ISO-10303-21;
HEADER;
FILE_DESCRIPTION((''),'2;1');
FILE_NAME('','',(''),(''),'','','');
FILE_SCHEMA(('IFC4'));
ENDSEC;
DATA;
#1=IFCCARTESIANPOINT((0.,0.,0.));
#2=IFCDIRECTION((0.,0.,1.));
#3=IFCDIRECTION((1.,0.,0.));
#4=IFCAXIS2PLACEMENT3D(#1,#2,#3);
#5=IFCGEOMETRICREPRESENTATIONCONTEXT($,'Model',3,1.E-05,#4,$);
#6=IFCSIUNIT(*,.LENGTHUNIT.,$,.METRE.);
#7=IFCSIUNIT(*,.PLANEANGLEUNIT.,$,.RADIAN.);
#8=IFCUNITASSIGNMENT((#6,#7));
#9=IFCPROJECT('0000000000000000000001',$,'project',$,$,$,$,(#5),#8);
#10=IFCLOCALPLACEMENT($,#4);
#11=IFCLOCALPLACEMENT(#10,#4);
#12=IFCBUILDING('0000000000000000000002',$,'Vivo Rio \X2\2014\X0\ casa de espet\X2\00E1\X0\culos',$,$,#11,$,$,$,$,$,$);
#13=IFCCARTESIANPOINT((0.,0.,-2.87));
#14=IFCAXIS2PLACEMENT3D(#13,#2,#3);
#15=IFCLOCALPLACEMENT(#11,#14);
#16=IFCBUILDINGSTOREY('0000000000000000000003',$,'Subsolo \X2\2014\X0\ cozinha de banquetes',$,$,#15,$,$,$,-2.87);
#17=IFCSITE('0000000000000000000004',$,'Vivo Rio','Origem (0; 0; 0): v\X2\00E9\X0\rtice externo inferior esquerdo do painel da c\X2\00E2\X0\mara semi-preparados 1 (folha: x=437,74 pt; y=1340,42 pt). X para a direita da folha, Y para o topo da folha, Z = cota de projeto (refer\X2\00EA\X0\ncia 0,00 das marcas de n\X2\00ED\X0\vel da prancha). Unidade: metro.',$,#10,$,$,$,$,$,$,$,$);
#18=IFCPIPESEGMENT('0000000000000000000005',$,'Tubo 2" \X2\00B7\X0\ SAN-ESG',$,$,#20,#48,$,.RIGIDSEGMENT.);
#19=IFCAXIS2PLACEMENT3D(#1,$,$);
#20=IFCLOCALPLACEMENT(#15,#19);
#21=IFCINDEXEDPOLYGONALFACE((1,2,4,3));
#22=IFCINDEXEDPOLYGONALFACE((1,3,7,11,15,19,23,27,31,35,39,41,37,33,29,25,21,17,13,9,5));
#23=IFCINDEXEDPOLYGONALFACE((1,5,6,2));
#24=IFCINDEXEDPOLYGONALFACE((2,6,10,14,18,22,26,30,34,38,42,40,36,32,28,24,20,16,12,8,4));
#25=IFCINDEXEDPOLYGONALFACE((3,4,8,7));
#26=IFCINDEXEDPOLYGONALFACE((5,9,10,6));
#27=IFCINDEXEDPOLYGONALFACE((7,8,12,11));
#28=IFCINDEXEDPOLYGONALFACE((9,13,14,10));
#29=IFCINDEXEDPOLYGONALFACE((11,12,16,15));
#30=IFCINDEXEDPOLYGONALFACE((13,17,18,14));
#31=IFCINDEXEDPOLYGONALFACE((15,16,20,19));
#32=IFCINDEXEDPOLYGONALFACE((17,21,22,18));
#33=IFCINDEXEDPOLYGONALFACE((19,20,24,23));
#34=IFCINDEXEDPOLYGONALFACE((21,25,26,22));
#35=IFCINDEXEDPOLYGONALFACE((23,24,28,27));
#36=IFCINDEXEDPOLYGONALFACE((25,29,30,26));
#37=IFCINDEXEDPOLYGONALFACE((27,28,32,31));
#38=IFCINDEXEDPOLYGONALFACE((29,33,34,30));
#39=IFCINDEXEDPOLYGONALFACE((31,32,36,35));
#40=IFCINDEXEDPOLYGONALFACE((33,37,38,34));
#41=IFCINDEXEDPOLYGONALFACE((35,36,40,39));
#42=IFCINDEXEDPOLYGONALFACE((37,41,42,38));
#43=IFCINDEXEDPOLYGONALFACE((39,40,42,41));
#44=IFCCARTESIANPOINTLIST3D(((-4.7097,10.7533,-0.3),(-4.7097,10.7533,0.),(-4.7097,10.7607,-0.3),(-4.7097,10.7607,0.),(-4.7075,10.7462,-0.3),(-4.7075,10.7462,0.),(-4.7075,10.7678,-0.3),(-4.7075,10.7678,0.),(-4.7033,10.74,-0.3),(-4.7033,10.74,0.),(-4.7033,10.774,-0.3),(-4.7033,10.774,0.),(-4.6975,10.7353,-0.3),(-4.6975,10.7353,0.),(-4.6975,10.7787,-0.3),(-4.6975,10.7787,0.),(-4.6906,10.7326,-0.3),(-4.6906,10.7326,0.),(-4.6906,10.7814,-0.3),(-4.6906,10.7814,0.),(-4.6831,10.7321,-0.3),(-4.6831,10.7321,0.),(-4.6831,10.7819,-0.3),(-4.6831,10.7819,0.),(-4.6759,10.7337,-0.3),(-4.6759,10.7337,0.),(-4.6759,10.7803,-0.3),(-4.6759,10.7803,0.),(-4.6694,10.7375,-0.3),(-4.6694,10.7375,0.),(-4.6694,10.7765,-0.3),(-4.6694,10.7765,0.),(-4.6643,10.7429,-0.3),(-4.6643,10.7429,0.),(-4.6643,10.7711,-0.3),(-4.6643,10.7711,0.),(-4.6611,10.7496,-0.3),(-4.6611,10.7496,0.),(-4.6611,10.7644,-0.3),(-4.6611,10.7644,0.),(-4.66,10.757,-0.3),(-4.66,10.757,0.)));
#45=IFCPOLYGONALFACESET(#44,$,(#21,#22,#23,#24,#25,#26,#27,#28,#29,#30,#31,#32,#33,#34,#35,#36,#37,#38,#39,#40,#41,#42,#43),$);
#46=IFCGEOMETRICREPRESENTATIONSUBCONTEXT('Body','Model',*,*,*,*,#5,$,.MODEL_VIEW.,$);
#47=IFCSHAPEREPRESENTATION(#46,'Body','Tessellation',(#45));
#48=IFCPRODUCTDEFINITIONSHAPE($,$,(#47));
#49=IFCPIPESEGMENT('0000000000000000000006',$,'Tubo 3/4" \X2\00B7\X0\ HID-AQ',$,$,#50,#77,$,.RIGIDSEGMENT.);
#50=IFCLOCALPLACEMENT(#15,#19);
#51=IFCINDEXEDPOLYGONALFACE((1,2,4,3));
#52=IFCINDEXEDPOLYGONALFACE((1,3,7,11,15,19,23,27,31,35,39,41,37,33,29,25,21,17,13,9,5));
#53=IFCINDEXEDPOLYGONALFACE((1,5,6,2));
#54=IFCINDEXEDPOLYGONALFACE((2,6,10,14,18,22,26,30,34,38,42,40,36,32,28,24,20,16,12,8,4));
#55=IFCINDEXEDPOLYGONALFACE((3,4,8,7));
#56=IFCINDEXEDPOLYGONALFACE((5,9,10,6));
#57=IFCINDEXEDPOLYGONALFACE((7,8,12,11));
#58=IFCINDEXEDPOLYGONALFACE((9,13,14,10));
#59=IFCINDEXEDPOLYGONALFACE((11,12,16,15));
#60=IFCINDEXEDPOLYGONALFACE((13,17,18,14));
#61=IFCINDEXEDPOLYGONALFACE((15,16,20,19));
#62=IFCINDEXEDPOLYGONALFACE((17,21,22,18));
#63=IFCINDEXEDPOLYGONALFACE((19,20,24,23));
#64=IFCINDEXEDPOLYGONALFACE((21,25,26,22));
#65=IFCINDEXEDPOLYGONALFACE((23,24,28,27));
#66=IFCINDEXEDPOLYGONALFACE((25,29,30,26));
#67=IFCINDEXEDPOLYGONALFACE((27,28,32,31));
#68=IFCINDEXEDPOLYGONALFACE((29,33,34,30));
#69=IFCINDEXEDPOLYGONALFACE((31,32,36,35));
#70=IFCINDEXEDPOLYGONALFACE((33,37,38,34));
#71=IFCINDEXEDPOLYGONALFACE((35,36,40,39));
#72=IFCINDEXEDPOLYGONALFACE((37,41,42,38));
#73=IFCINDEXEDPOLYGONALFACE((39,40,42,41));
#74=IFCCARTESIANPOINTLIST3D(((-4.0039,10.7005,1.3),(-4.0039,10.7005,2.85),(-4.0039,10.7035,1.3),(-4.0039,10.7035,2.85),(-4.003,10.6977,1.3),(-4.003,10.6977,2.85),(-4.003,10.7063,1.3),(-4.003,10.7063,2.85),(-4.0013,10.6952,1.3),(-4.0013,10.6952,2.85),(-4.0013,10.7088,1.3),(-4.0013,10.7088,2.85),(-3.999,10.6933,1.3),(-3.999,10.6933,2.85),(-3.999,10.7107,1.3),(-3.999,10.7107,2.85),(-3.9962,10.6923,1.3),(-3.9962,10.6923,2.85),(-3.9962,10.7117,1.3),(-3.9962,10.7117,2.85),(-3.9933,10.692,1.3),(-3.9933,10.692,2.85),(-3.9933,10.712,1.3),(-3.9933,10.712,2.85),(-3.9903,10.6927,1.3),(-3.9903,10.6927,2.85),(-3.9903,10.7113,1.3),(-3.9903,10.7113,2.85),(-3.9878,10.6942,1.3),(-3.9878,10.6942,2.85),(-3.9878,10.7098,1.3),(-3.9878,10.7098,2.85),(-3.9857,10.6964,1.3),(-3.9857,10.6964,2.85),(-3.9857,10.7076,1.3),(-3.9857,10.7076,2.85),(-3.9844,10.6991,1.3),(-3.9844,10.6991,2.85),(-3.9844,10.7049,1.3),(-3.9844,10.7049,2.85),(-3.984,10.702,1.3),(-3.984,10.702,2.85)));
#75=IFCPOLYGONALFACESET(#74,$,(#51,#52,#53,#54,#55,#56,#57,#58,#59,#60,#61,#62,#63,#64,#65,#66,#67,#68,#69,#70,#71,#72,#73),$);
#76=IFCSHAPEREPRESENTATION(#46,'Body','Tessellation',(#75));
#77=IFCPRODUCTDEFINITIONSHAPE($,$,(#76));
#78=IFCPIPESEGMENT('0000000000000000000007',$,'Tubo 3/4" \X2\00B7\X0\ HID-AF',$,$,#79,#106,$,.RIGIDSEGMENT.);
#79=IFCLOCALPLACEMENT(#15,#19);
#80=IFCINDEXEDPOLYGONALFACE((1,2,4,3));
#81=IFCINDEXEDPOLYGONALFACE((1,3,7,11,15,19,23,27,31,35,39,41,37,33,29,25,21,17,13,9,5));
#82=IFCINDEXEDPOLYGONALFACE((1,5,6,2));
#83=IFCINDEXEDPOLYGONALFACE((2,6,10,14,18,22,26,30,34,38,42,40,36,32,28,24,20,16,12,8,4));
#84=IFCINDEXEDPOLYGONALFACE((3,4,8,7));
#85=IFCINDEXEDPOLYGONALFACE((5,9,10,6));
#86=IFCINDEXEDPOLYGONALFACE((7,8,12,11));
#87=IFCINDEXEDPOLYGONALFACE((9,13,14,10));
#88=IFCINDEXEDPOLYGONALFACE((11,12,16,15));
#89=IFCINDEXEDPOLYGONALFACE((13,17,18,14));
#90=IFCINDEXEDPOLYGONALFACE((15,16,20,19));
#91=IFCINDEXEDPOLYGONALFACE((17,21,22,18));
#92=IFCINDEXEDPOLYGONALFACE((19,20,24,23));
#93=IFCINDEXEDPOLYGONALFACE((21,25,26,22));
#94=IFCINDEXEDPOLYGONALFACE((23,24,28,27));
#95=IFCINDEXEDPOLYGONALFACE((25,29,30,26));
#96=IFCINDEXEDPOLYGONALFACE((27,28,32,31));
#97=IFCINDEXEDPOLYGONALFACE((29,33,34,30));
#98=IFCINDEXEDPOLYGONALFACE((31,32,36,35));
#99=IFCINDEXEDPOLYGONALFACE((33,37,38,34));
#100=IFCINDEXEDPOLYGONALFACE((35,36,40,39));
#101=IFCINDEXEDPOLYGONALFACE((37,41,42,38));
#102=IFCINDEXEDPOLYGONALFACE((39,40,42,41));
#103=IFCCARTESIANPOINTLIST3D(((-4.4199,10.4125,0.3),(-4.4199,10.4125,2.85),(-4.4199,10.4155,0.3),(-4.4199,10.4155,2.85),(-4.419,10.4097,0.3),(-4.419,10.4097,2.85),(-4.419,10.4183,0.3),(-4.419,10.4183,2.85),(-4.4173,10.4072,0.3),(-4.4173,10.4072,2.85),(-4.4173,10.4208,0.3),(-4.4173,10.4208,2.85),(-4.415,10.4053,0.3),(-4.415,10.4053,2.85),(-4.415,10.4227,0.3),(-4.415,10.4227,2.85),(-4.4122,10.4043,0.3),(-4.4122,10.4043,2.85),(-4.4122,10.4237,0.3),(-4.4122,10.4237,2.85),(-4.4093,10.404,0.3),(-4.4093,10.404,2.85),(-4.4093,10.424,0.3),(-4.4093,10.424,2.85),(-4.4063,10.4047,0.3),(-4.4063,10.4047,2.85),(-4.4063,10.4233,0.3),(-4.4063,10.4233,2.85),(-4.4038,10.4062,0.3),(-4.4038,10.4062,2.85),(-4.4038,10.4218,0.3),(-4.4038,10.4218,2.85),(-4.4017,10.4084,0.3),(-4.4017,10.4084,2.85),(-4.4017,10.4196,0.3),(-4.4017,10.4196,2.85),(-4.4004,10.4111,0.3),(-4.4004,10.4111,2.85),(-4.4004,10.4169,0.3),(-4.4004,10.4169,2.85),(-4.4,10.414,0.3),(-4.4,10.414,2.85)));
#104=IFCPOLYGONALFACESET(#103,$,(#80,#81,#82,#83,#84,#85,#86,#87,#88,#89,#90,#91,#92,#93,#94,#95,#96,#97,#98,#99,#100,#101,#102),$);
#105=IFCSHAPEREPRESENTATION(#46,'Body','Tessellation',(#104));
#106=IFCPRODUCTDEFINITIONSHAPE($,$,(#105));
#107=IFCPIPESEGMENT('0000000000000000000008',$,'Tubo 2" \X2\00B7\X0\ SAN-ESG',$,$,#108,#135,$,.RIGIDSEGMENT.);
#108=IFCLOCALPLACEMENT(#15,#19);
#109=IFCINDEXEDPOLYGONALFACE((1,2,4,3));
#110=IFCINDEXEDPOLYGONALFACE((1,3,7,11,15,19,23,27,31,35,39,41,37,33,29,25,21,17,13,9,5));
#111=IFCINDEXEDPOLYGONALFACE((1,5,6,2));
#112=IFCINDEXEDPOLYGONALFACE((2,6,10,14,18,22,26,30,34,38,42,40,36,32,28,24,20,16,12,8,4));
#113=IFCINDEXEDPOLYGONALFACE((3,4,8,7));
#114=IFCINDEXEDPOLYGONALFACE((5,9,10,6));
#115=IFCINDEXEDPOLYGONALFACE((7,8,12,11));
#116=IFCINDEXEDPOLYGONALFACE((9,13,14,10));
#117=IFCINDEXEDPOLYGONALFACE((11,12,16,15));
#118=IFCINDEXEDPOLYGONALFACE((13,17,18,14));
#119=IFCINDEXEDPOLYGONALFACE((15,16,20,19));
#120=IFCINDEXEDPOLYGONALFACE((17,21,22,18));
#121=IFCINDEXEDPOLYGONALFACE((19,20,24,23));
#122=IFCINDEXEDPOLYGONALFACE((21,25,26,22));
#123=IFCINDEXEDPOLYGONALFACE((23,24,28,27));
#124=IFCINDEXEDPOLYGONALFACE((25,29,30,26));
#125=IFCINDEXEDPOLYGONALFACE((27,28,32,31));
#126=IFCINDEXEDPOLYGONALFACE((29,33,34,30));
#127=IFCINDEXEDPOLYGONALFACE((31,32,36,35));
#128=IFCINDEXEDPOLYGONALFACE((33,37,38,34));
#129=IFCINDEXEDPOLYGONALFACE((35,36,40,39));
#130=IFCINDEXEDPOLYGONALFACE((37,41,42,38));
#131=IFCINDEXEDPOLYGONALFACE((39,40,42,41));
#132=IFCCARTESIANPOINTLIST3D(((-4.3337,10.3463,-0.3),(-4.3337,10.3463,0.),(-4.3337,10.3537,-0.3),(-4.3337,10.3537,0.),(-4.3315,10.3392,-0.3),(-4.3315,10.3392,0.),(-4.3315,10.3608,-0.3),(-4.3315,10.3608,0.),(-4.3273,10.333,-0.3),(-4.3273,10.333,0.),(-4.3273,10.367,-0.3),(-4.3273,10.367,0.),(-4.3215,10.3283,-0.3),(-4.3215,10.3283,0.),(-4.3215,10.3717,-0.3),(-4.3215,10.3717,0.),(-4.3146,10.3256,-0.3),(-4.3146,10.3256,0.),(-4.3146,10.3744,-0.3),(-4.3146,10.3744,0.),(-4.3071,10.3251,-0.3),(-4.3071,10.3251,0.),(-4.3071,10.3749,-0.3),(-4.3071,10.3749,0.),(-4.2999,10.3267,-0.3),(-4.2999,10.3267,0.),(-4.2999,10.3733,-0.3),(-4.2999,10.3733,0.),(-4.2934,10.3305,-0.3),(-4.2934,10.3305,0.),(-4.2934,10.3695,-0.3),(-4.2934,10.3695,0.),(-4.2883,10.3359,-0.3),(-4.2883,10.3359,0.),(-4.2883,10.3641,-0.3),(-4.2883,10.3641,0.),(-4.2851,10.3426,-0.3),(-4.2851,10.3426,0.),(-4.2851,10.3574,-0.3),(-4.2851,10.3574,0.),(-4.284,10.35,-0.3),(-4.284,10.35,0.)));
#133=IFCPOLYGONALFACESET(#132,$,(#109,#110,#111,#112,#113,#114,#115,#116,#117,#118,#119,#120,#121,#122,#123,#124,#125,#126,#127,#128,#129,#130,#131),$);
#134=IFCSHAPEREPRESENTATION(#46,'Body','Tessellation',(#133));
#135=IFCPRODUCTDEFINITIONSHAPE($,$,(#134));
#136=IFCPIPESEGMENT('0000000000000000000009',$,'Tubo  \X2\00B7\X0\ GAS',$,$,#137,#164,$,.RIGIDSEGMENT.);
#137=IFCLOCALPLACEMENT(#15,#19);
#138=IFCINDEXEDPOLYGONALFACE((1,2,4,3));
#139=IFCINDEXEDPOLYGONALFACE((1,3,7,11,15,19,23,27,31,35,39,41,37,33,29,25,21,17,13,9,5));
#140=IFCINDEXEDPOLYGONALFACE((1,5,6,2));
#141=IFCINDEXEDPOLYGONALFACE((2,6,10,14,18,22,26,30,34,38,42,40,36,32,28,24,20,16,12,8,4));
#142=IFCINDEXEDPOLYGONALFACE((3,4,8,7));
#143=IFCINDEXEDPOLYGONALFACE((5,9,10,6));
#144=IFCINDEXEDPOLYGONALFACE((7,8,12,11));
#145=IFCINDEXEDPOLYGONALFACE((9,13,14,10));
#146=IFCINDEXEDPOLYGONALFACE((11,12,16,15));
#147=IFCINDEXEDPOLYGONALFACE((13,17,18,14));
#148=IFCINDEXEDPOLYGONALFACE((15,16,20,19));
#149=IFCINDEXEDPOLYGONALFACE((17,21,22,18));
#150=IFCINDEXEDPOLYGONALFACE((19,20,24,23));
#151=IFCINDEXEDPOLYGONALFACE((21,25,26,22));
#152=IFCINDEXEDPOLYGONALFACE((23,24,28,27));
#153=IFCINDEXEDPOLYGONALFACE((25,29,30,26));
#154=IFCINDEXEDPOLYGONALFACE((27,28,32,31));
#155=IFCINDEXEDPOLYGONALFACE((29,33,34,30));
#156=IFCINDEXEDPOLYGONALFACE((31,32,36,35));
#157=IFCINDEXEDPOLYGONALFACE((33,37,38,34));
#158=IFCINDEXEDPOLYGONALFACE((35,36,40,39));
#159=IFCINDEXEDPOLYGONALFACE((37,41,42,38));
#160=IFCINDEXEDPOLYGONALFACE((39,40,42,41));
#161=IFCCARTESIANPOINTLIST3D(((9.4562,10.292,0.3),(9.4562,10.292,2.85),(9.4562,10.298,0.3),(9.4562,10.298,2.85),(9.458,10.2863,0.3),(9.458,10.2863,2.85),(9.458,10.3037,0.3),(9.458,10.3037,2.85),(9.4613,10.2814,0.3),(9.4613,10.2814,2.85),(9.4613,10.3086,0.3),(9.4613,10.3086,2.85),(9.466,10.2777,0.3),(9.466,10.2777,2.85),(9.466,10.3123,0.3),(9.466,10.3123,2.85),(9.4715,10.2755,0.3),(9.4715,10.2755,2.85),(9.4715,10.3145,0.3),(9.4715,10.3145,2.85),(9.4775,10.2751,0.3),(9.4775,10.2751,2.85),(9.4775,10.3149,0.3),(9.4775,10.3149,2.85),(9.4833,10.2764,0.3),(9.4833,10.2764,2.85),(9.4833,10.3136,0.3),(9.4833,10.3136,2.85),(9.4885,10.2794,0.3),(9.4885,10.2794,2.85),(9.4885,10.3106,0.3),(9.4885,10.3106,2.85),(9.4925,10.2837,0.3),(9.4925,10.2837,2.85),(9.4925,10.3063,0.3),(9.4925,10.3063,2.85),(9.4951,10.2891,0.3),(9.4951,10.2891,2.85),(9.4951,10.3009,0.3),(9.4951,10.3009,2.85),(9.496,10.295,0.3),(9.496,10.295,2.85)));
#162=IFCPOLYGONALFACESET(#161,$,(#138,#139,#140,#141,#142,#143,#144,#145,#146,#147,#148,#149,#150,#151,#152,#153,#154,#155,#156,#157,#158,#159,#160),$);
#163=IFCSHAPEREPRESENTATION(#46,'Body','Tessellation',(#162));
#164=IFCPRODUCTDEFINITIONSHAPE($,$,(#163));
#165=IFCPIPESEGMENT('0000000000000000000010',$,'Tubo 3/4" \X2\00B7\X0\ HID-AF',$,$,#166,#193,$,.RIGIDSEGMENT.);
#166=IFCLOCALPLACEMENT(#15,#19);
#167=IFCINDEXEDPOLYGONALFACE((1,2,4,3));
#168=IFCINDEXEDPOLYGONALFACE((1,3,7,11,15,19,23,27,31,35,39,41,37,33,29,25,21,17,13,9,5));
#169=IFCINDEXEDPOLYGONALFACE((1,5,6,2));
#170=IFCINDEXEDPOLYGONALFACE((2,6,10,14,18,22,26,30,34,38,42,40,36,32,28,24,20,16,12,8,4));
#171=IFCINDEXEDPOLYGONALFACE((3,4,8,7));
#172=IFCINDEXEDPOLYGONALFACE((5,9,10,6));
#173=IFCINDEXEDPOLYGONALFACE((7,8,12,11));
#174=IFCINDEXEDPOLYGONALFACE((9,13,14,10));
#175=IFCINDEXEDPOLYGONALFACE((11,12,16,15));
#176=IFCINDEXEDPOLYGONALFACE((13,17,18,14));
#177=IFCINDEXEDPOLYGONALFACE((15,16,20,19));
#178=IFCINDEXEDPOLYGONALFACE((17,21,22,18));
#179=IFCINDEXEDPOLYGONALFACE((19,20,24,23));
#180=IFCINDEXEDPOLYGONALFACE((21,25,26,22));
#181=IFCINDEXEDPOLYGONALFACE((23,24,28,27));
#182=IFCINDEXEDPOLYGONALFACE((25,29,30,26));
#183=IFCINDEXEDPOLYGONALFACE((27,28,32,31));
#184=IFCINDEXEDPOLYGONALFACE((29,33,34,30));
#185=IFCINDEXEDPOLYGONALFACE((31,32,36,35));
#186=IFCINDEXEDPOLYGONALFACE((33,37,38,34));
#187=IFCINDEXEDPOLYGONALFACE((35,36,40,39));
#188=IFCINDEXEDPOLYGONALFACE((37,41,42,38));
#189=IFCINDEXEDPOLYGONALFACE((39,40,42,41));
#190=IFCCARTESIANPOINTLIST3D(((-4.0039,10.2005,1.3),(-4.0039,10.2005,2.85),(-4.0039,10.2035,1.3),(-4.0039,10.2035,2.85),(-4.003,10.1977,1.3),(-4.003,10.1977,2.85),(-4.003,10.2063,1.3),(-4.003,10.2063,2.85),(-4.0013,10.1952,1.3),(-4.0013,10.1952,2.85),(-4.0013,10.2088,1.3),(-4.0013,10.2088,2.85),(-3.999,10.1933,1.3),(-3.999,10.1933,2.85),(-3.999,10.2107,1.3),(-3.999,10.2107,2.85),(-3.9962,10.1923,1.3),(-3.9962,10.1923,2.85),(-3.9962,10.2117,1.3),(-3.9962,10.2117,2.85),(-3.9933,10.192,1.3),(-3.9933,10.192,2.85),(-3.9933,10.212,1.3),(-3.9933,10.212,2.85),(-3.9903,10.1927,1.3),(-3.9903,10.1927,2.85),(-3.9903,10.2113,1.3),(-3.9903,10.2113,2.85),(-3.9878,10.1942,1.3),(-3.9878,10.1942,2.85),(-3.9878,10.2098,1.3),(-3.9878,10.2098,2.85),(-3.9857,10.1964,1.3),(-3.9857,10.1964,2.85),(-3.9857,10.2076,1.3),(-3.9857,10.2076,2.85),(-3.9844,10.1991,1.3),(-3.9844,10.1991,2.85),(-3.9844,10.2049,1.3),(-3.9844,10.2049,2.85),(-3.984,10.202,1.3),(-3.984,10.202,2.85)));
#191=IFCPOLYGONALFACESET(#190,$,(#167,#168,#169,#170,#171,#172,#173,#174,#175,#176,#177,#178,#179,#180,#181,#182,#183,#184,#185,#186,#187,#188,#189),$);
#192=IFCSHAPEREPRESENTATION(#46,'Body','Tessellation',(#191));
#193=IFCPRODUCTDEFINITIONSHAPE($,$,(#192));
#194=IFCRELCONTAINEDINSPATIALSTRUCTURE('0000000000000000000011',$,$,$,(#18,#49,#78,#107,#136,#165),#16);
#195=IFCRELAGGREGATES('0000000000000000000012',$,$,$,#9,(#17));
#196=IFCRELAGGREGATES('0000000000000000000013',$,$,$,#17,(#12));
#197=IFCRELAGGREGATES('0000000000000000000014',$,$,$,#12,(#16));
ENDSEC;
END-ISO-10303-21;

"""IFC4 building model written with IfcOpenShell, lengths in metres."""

from ifc_helpers import new_model, si_unit, frame, origin_with_axes, origin_2d, place, context, subcontext, project, spatial, circle, extrude, element, save


model = new_model("IFC4")

# Units and contexts
model_context = context("Model", 3, precision=1e-05, world=origin_with_axes())
body_context = subcontext(model_context, "Body", "Model", "MODEL_VIEW")
ifc_project = project(units=[si_unit("LENGTHUNIT", "METRE"), si_unit("PLANEANGLEUNIT", "RADIAN")], contexts=[model_context])

# Site, building, storey
site_placement = place(None, origin_with_axes())
site = spatial("IfcSite", under=ifc_project, at=site_placement, Name="Vivo Rio", Description="Origem (0; 0; 0): vértice externo inferior esquerdo do painel da câmara semi-preparados 1 (folha: x=437,74 pt; y=1340,42 pt). X para a direita da folha, Y para o topo da folha, Z = cota de projeto (referência 0,00 das marcas de nível da prancha). Unidade: metro.")
building_placement = place(site_placement, origin_with_axes())
building = spatial("IfcBuilding", under=site, at=building_placement, Name="Vivo Rio — casa de espetáculos")
storey_placement = place(building_placement, frame((0.0, 0.0, -2.87), z_axis=(0.0, 0.0, 1.0), x_axis=(1.0, 0.0, 0.0)))
storey = spatial("IfcBuildingStorey", under=building, at=storey_placement, Name="Subsolo — cozinha de banquetes", Elevation=-2.87)

# Pipe segments
pipe_segment_1_placement = place(storey_placement, origin_with_axes())
element("IfcPipeSegment", 1, at=pipe_segment_1_placement, inside=storey, Name="Tubo 2\" · SAN-ESG", PredefinedType="RIGIDSEGMENT", context=body_context, shape_type="SweptSolid", body=[
    extrude(circle(Radius=0.025, at=origin_2d()), frame((-4.685, 10.757, 0.0), z_axis=(0.0, 0.0, -1.0), x_axis=(1.0, 0.0, 0.0)), (0.0, 0.0, 1.0), 0.3),
])
pipe_segment_2_placement = place(storey_placement, origin_with_axes())
element("IfcPipeSegment", 2, at=pipe_segment_2_placement, inside=storey, Name="Tubo 3/4\" · HID-AQ", PredefinedType="RIGIDSEGMENT", context=body_context, shape_type="SweptSolid", body=[
    extrude(circle(Radius=0.01, at=origin_2d()), frame((-3.994, 10.702, 2.85), z_axis=(0.0, 0.0, -1.0), x_axis=(1.0, 0.0, 0.0)), (0.0, 0.0, 1.0), 1.55),
])
pipe_segment_3_placement = place(storey_placement, origin_with_axes())
element("IfcPipeSegment", 3, at=pipe_segment_3_placement, inside=storey, Name="Tubo 3/4\" · HID-AF", PredefinedType="RIGIDSEGMENT", context=body_context, shape_type="SweptSolid", body=[
    extrude(circle(Radius=0.01, at=origin_2d()), frame((-4.41, 10.414, 2.85), z_axis=(0.0, 0.0, -1.0), x_axis=(1.0, 0.0, 0.0)), (0.0, 0.0, 1.0), 2.55),
])
pipe_segment_4_placement = place(storey_placement, origin_with_axes())
element("IfcPipeSegment", 4, at=pipe_segment_4_placement, inside=storey, Name="Tubo 2\" · SAN-ESG", PredefinedType="RIGIDSEGMENT", context=body_context, shape_type="SweptSolid", body=[
    extrude(circle(Radius=0.025, at=origin_2d()), frame((-4.309, 10.35, 0.0), z_axis=(0.0, 0.0, -1.0), x_axis=(1.0, 0.0, 0.0)), (0.0, 0.0, 1.0), 0.3),
])
pipe_segment_5_placement = place(storey_placement, origin_with_axes())
element("IfcPipeSegment", 5, at=pipe_segment_5_placement, inside=storey, Name="Tubo  · GAS", PredefinedType="RIGIDSEGMENT", context=body_context, shape_type="SweptSolid", body=[
    extrude(circle(Radius=0.02, at=origin_2d()), frame((9.476, 10.295, 2.85), z_axis=(0.0, 0.0, -1.0), x_axis=(1.0, 0.0, 0.0)), (0.0, 0.0, 1.0), 2.55),
])
pipe_segment_6_placement = place(storey_placement, origin_with_axes())
element("IfcPipeSegment", 6, at=pipe_segment_6_placement, inside=storey, Name="Tubo 3/4\" · HID-AF", PredefinedType="RIGIDSEGMENT", context=body_context, shape_type="SweptSolid", body=[
    extrude(circle(Radius=0.01, at=origin_2d()), frame((-3.994, 10.202, 2.85), z_axis=(0.0, 0.0, -1.0), x_axis=(1.0, 0.0, 0.0)), (0.0, 0.0, 1.0), 1.55),
])

save(model, "model.ifc")
